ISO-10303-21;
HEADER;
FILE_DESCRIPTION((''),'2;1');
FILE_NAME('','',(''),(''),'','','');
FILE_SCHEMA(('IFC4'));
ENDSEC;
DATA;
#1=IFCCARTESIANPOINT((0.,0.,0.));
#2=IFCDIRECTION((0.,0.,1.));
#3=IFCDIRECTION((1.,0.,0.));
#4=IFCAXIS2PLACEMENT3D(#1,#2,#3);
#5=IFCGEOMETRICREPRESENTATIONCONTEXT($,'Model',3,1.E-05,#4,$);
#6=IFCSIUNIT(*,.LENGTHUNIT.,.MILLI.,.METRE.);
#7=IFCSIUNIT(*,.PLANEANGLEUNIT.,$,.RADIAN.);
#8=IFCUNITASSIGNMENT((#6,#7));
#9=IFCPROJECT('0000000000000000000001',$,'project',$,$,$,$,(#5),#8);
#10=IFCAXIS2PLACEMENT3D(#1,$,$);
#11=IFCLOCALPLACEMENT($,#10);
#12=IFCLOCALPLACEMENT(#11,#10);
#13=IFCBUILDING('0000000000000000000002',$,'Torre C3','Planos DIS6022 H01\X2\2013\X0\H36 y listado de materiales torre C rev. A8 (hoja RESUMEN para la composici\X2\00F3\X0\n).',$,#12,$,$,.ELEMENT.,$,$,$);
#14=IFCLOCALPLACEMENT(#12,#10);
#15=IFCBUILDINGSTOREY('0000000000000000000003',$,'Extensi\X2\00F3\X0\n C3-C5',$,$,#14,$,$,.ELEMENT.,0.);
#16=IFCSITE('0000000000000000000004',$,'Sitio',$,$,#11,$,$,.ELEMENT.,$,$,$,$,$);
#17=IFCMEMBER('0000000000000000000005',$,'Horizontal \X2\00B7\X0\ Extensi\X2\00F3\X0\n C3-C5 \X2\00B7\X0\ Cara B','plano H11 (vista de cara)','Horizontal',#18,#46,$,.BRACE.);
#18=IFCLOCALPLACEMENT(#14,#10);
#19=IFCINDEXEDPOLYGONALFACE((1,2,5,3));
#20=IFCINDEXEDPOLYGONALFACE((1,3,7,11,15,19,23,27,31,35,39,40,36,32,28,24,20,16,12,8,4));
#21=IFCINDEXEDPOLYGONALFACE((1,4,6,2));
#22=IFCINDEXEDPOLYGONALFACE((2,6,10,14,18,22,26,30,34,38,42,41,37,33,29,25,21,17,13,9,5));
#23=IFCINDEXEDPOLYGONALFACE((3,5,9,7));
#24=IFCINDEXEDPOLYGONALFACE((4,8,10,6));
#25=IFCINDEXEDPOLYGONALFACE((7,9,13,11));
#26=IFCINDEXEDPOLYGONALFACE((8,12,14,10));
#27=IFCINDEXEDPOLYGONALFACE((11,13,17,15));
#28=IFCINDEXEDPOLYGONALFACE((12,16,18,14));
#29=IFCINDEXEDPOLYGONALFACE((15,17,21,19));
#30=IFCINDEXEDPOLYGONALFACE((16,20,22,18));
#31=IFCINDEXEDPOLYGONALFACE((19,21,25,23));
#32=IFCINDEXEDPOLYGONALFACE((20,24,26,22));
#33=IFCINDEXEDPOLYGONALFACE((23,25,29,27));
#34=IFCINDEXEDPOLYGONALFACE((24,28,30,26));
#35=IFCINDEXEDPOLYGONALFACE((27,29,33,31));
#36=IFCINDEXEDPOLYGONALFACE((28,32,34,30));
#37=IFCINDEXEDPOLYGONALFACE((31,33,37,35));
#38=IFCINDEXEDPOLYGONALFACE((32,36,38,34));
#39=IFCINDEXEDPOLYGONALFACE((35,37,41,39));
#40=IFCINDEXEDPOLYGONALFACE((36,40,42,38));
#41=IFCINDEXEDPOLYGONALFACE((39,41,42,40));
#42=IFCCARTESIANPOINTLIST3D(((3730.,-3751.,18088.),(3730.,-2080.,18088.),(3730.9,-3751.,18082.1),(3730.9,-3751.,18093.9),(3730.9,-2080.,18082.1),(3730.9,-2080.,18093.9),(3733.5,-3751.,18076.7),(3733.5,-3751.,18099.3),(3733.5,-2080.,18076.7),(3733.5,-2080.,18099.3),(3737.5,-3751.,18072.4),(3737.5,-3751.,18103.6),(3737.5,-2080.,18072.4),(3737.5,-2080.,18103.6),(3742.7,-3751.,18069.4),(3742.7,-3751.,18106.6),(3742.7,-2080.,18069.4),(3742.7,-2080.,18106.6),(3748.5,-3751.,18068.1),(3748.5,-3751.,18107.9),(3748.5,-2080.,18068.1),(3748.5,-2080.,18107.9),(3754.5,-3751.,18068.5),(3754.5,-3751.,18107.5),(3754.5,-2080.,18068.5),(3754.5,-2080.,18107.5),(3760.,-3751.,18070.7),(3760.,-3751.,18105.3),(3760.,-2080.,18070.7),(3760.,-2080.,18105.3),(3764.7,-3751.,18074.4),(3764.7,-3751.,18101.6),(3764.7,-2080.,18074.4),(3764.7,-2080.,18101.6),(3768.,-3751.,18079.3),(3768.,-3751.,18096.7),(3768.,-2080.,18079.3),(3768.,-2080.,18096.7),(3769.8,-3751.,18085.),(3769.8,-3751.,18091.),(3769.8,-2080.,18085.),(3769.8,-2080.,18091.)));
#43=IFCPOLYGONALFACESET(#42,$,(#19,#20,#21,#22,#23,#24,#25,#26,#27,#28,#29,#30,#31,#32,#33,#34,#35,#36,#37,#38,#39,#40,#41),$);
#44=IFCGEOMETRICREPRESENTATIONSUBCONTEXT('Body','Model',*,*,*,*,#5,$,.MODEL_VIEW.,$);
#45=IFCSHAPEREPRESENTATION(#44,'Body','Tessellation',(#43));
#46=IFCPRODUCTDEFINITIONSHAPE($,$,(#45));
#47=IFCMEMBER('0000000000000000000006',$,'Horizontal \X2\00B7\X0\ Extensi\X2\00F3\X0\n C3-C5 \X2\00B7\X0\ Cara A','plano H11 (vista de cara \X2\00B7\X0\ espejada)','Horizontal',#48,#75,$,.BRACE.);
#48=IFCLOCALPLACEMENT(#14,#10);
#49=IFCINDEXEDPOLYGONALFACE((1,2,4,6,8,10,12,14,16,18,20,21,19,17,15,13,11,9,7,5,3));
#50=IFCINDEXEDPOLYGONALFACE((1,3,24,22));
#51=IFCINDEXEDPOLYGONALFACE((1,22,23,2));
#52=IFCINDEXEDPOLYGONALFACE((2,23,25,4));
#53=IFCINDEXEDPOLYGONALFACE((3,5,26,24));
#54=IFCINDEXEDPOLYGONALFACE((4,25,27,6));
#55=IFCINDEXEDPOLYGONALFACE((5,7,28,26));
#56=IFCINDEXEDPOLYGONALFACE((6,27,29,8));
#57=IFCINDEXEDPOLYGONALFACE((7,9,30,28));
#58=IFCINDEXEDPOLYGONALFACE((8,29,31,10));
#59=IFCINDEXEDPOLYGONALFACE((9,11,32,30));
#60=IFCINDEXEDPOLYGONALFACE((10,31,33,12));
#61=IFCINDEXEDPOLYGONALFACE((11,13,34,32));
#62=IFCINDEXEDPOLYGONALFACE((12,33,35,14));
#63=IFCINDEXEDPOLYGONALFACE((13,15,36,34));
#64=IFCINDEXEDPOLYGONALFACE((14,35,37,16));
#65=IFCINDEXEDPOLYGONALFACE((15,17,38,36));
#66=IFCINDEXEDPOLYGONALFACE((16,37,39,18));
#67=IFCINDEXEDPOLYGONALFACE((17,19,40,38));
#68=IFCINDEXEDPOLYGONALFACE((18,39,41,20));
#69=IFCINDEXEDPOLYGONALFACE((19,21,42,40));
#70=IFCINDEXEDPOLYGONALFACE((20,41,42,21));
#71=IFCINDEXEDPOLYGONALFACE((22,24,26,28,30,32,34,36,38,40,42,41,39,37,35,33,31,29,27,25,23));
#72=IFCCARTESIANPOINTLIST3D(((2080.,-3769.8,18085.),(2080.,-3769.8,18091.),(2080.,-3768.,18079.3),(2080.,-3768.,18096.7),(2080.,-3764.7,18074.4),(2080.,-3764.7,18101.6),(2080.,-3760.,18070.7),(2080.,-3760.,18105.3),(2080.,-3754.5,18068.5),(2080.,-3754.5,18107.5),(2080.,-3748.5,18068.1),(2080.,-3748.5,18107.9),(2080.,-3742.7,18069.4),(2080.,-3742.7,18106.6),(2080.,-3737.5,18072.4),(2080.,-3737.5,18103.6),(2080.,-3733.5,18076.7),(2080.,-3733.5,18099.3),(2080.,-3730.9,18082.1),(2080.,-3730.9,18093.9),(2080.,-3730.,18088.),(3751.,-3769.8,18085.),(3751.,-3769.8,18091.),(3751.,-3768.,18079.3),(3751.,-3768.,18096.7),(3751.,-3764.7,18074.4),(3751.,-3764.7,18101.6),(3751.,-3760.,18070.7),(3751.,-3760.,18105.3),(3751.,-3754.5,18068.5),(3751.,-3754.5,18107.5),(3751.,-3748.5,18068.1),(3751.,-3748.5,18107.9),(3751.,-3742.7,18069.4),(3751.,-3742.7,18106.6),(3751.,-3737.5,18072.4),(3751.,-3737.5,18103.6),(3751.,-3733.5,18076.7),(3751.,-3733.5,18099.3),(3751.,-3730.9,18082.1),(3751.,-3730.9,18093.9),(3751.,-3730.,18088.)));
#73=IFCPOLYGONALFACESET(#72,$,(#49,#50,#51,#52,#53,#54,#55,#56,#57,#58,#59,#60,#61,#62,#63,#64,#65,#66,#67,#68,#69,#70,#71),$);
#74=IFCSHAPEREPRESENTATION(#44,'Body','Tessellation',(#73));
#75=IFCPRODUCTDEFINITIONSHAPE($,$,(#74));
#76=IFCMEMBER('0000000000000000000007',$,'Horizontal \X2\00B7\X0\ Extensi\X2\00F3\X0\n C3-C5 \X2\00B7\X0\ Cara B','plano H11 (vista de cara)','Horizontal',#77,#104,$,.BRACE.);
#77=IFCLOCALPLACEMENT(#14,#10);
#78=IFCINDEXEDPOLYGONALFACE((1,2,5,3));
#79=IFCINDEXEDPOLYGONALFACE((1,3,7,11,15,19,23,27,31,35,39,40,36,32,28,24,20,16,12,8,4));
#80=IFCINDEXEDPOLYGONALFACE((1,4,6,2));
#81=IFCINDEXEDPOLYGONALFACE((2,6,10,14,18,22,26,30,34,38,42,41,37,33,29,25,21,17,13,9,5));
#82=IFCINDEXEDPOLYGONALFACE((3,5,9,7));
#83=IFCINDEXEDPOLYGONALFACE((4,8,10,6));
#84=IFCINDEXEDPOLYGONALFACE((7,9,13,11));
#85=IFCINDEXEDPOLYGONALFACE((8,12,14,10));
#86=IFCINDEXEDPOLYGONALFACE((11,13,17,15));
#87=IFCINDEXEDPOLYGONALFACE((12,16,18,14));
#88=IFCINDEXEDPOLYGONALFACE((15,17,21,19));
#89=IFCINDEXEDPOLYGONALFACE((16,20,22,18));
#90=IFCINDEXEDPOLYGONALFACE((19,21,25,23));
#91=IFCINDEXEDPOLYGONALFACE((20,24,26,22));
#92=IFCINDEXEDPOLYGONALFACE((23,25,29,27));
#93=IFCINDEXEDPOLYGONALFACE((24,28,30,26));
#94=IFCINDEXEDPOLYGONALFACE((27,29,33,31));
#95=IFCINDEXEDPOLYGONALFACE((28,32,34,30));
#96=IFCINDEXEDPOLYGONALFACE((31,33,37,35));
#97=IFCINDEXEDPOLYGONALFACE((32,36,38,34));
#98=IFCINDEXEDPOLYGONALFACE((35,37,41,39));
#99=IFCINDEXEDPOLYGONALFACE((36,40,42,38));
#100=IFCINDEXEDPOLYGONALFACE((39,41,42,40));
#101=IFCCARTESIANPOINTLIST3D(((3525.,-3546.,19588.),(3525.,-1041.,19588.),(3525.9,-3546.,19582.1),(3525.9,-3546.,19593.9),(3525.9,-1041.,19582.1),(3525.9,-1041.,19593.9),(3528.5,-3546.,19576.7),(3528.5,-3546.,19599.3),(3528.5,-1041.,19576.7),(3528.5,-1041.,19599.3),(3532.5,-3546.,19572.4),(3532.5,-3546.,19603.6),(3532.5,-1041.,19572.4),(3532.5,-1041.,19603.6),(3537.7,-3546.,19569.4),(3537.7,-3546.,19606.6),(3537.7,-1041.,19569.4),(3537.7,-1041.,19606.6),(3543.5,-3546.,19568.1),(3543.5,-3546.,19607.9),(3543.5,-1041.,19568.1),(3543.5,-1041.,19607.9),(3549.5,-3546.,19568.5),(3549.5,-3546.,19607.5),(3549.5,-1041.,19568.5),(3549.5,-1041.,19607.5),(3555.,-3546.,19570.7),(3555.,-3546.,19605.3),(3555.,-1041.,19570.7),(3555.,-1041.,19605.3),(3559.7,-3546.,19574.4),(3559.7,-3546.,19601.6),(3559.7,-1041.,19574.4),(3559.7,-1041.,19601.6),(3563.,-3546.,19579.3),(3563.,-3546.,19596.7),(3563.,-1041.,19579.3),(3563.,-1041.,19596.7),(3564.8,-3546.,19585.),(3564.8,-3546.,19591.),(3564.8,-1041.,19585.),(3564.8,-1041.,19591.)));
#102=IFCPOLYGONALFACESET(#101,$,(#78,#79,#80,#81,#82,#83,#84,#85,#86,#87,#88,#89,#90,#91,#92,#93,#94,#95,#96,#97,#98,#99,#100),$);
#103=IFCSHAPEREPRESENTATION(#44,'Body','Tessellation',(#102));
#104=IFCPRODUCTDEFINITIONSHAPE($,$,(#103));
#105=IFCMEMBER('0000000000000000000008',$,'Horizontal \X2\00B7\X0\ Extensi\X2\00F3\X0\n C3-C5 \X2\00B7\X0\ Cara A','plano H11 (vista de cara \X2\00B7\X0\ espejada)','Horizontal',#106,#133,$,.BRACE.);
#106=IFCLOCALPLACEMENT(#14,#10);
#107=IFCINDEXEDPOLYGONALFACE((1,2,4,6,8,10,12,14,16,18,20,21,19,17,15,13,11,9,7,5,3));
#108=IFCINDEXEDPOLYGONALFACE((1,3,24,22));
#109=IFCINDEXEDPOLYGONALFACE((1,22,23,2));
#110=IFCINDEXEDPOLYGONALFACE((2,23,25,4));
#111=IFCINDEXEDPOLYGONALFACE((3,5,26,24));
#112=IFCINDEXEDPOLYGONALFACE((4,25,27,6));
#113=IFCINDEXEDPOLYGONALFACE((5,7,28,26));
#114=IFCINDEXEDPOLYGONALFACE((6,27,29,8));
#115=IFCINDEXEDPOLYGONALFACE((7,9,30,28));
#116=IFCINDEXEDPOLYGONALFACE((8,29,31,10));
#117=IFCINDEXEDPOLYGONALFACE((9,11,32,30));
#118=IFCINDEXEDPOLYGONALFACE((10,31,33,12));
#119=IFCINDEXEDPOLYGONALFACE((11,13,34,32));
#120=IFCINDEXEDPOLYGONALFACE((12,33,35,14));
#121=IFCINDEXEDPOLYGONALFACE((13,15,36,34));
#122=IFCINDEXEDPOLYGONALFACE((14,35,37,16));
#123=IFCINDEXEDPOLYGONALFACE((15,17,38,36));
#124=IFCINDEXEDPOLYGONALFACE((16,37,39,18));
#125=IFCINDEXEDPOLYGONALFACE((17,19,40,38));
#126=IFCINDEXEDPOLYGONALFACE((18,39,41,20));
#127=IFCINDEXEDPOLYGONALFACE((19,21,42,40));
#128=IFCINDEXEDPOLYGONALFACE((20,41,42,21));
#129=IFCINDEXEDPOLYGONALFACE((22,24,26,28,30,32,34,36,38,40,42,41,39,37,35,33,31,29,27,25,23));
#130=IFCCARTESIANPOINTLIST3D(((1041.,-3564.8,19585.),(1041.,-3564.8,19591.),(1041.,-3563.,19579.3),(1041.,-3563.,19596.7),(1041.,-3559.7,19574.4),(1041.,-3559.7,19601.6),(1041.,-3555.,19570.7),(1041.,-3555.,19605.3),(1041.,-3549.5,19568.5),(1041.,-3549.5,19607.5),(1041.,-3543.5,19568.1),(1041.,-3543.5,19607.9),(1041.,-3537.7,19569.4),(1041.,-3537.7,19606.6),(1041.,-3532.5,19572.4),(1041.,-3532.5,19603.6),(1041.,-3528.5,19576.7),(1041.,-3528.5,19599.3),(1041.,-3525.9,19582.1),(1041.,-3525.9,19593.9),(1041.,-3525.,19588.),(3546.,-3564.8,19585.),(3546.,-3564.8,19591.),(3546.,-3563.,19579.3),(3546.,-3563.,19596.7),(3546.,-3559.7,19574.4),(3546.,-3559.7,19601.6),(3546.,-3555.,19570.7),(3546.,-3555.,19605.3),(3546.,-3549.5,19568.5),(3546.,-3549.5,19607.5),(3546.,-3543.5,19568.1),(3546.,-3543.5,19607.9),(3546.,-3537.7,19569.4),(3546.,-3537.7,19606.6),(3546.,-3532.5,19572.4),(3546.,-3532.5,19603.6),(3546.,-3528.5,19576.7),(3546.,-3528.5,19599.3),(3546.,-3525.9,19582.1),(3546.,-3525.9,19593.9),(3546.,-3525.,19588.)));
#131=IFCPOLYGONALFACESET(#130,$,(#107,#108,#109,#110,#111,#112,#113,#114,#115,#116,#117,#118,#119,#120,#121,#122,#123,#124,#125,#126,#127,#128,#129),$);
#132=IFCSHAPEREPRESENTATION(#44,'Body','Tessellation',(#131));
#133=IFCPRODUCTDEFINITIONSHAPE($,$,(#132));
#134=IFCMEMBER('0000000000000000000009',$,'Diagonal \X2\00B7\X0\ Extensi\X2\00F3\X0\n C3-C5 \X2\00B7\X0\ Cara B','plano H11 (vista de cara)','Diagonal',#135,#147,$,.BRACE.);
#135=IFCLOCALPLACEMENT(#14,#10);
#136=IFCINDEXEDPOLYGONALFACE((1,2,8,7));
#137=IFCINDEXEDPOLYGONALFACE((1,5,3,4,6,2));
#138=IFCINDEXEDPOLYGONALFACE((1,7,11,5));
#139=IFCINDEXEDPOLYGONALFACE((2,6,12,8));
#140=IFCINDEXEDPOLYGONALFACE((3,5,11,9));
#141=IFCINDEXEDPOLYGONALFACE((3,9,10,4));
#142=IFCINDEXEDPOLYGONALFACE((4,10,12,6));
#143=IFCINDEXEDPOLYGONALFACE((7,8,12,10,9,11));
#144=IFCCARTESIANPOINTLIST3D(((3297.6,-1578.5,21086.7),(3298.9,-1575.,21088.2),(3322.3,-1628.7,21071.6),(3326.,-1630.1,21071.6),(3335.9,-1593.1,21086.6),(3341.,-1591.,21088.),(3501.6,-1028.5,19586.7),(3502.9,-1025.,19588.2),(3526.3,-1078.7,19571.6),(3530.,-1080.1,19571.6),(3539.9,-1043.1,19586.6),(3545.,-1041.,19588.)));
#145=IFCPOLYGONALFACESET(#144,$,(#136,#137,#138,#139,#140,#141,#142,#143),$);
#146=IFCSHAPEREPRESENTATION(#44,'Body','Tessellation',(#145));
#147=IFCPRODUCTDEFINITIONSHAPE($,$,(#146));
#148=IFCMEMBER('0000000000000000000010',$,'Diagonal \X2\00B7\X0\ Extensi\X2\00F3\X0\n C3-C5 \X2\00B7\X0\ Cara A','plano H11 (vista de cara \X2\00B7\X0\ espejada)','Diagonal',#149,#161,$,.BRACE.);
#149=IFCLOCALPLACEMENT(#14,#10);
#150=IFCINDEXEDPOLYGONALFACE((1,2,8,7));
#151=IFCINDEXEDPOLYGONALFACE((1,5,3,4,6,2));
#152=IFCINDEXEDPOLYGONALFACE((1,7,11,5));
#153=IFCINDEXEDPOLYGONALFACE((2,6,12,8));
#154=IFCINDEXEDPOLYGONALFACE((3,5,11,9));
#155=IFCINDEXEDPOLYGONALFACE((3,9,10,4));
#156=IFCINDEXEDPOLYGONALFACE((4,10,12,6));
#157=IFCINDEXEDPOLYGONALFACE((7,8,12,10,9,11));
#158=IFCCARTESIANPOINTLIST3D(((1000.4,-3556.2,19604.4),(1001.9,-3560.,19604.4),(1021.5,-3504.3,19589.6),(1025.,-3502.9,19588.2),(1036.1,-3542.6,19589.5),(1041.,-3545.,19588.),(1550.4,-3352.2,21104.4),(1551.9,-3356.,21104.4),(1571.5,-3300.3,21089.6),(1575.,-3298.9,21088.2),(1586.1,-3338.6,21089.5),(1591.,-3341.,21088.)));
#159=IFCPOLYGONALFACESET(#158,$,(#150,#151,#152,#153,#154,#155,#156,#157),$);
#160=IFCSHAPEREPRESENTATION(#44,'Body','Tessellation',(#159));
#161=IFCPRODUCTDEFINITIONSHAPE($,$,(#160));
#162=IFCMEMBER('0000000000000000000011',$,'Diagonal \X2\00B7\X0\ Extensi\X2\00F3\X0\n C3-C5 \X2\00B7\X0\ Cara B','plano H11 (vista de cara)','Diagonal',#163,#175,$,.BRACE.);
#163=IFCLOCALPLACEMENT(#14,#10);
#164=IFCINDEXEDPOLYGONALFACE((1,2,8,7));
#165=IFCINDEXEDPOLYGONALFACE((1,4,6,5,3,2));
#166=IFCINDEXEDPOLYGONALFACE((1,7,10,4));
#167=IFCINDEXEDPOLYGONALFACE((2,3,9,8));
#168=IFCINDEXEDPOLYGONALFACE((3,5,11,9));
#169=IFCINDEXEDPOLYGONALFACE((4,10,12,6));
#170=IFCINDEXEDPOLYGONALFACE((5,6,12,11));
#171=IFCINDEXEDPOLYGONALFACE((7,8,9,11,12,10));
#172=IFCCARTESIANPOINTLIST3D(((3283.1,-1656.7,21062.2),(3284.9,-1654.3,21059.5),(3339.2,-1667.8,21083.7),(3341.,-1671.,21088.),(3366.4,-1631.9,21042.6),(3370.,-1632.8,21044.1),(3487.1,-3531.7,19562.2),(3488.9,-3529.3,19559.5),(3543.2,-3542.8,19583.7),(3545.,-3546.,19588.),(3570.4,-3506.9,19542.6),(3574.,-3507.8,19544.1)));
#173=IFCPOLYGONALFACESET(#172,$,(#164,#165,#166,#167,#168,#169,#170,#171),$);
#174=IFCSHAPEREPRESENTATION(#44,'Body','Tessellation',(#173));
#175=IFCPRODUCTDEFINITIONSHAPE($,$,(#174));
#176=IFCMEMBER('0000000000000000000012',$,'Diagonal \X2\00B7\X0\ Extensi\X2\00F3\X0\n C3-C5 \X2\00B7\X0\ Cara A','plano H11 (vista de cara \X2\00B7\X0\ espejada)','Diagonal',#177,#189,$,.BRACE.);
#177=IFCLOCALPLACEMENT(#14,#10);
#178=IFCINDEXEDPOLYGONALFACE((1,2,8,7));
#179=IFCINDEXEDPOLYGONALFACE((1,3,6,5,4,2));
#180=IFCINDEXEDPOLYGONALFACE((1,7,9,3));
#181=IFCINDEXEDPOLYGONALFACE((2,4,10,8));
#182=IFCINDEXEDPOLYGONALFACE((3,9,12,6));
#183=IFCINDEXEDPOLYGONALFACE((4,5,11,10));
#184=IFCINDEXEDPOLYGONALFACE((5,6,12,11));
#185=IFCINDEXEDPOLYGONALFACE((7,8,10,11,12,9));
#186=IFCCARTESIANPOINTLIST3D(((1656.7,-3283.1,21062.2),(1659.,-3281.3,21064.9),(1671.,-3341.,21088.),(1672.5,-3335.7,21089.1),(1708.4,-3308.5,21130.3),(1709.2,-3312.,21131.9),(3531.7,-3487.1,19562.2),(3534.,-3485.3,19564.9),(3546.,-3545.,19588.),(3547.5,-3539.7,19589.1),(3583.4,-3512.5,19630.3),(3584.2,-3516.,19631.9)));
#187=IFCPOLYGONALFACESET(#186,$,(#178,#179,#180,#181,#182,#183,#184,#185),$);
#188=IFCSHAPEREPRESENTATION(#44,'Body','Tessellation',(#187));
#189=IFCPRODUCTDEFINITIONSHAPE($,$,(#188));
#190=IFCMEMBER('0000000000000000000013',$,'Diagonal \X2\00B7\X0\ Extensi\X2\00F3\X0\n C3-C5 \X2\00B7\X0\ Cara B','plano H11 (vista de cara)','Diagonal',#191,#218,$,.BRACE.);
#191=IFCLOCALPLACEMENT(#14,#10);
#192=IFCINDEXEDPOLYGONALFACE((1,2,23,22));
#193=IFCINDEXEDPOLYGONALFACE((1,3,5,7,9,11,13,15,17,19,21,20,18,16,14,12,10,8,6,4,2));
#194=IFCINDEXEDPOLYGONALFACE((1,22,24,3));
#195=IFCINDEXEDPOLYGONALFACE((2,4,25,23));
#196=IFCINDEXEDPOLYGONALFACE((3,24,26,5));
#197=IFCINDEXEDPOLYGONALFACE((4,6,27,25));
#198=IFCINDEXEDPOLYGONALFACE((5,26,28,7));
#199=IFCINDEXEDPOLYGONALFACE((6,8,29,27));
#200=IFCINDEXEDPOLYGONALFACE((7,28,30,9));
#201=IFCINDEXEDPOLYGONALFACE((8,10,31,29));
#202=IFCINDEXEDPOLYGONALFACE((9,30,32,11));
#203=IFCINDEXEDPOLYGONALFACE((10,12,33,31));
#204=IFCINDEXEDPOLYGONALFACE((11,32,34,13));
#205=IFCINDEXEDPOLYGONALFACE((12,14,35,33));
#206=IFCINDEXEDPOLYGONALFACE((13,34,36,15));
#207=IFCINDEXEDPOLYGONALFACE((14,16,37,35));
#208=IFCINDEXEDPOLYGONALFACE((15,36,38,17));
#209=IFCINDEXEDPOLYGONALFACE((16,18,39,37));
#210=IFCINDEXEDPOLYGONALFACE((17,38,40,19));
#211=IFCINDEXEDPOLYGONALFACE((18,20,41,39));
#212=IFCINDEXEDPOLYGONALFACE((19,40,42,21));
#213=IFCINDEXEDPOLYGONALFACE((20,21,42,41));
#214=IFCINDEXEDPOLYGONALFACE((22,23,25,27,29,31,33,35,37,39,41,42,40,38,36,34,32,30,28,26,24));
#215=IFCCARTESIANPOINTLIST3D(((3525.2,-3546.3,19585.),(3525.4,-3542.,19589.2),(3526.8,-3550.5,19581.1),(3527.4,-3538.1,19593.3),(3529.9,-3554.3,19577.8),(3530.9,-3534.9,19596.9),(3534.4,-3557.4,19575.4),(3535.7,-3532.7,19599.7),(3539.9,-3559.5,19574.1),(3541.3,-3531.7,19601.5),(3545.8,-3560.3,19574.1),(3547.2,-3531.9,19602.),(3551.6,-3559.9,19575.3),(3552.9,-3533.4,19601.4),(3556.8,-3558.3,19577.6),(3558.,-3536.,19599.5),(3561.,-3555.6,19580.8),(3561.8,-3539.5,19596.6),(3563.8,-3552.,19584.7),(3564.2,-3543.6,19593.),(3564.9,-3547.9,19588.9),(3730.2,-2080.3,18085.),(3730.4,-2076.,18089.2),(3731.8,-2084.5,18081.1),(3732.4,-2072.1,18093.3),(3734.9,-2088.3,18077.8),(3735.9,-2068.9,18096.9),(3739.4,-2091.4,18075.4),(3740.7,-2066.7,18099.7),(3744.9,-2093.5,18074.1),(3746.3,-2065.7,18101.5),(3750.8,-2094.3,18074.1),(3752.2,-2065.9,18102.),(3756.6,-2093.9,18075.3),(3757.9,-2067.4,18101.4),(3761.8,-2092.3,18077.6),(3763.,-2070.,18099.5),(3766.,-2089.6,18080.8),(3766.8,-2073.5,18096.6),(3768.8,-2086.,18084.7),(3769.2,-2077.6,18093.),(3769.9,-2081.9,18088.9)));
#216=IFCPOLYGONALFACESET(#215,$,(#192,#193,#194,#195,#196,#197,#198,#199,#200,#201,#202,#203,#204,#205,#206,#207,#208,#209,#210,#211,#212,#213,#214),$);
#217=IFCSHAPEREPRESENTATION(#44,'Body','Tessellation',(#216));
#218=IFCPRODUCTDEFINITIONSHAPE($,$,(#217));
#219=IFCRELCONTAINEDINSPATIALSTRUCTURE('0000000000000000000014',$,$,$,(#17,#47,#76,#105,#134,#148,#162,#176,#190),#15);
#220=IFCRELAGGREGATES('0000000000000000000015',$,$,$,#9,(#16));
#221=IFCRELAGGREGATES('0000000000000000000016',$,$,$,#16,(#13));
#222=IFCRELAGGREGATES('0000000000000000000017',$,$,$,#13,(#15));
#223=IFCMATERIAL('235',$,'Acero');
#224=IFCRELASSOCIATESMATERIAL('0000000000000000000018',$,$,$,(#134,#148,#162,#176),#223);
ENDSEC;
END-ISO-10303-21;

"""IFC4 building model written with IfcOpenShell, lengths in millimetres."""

from ifc_helpers import new_model, si_unit, frame, frame_2d, origin, origin_with_axes, place, context, subcontext, project, spatial, circle, l_section, extrude, material, element, save


model = new_model("IFC4")

# Units and contexts
model_context = context("Model", 3, precision=1e-05, world=origin_with_axes())
body_context = subcontext(model_context, "Body", "Model", "MODEL_VIEW")
ifc_project = project(units=[si_unit("LENGTHUNIT", "METRE", prefix="MILLI"), si_unit("PLANEANGLEUNIT", "RADIAN")], contexts=[model_context])

# Site, building, storey
site_placement = place(None, origin())
site = spatial("IfcSite", under=ifc_project, at=site_placement, Name="Sitio", CompositionType="ELEMENT")
building_placement = place(site_placement, origin())
building = spatial("IfcBuilding", under=site, at=building_placement, Name="Torre C3", Description="Planos DIS6022 H01–H36 y listado de materiales torre C rev. A8 (hoja RESUMEN para la composición).", CompositionType="ELEMENT")
storey_placement = place(building_placement, origin())
storey = spatial("IfcBuildingStorey", under=building, at=storey_placement, Name="Extensión C3-C5", CompositionType="ELEMENT", Elevation=0.0)

# Members
for number, where, z_axis, x_axis, name, description in (
    (1, (3750.0, -2080.0, 18088.0), (0.0, -1.0, 0.0), (-1.0, 0.0, 0.0), "Horizontal · Extensión C3-C5 · Cara B", "plano H11 (vista de cara)"),
    (2, (2080.0, -3750.0, 18088.0), (1.0, 0.0, 0.0), (0.0, 1.0, 0.0), "Horizontal · Extensión C3-C5 · Cara A", "plano H11 (vista de cara · espejada)"),
):
    element("IfcMember", number, at=place(storey_placement, frame(where, z_axis=z_axis, x_axis=x_axis)), inside=storey, Name=name, Description=description, ObjectType="Horizontal", PredefinedType="BRACE", context=body_context, shape_type="SweptSolid", body=[
        extrude(circle(Radius=20.0), None, (0.0, 0.0, 1.0), 1671.0),
    ])
for number, where, z_axis, x_axis, name, description in (
    (3, (3545.0, -1041.0, 19588.0), (0.0, -1.0, 0.0), (-1.0, 0.0, 0.0), "Horizontal · Extensión C3-C5 · Cara B", "plano H11 (vista de cara)"),
    (4, (1041.0, -3545.0, 19588.0), (1.0, 0.0, 0.0), (0.0, 1.0, 0.0), "Horizontal · Extensión C3-C5 · Cara A", "plano H11 (vista de cara · espejada)"),
):
    element("IfcMember", number, at=place(storey_placement, frame(where, z_axis=z_axis, x_axis=x_axis)), inside=storey, Name=name, Description=description, ObjectType="Horizontal", PredefinedType="BRACE", context=body_context, shape_type="SweptSolid", body=[
        extrude(circle(Radius=20.0), None, (0.0, 0.0, 1.0), 2505.0),
    ])
ifc_material_1 = material(Name="235", Category="Acero")
for number, where, z_axis, x_axis, name, description in (
    (5, (3545.0, -1041.0, 19588.0), (-0.126659, -0.341482, 0.931315), (-0.934555, 0.355803, 0.003362), "Diagonal · Extensión C3-C5 · Cara B", "plano H11 (vista de cara)"),
    (6, (1041.0, -3545.0, 19588.0), (0.341482, 0.126659, 0.931315), (-0.355803, 0.934555, 0.003362), "Diagonal · Extensión C3-C5 · Cara A", "plano H11 (vista de cara · espejada)"),
):
    element("IfcMember", number, at=place(storey_placement, frame(where, z_axis=z_axis, x_axis=x_axis)), inside=storey, material=ifc_material_1, Name=name, Description=description, ObjectType="Diagonal", PredefinedType="BRACE", context=body_context, shape_type="SweptSolid", body=[
        extrude(l_section(Depth=45.0, Width=45.0, Thickness=4.0, at=frame_2d((22.5, 22.5))), None, (0.0, 0.0, 1.0), 1610.6),
    ])
for number, where, z_axis, x_axis, name, description in (
    (7, (3341.0, -1671.0, 21088.0), (0.084654, -0.778066, -0.622453), (-0.891172, 0.220307, -0.396583), "Diagonal · Extensión C3-C5 · Cara B", "plano H11 (vista de cara)"),
    (8, (1671.0, -3341.0, 21088.0), (0.778066, -0.084654, -0.622453), (-0.220307, 0.891172, -0.396583), "Diagonal · Extensión C3-C5 · Cara A", "plano H11 (vista de cara · espejada)"),
):
    element("IfcMember", number, at=place(storey_placement, frame(where, z_axis=z_axis, x_axis=x_axis)), inside=storey, material=ifc_material_1, Name=name, Description=description, ObjectType="Diagonal", PredefinedType="BRACE", context=body_context, shape_type="SweptSolid", body=[
        extrude(l_section(Depth=65.0, Width=65.0, Thickness=4.0, at=frame_2d((32.5, 32.5))), None, (0.0, 0.0, 1.0), 2409.8),
    ])
for number, where, z_axis, x_axis, name in (
    (9, (3545.0, -3546.0, 19588.0), (0.097276, 0.69564, -0.711774), (-0.880677, 0.39331, 0.264036), "Diagonal · Extensión C3-C5 · Cara B"),
):
    element("IfcMember", number, at=place(storey_placement, frame(where, z_axis=z_axis, x_axis=x_axis)), inside=storey, Name=name, Description="plano H11 (vista de cara)", ObjectType="Diagonal", PredefinedType="BRACE", context=body_context, shape_type="SweptSolid", body=[
        extrude(circle(Radius=20.0), None, (0.0, 0.0, 1.0), 2107.4),
    ])

save(model, "model.ifc")
